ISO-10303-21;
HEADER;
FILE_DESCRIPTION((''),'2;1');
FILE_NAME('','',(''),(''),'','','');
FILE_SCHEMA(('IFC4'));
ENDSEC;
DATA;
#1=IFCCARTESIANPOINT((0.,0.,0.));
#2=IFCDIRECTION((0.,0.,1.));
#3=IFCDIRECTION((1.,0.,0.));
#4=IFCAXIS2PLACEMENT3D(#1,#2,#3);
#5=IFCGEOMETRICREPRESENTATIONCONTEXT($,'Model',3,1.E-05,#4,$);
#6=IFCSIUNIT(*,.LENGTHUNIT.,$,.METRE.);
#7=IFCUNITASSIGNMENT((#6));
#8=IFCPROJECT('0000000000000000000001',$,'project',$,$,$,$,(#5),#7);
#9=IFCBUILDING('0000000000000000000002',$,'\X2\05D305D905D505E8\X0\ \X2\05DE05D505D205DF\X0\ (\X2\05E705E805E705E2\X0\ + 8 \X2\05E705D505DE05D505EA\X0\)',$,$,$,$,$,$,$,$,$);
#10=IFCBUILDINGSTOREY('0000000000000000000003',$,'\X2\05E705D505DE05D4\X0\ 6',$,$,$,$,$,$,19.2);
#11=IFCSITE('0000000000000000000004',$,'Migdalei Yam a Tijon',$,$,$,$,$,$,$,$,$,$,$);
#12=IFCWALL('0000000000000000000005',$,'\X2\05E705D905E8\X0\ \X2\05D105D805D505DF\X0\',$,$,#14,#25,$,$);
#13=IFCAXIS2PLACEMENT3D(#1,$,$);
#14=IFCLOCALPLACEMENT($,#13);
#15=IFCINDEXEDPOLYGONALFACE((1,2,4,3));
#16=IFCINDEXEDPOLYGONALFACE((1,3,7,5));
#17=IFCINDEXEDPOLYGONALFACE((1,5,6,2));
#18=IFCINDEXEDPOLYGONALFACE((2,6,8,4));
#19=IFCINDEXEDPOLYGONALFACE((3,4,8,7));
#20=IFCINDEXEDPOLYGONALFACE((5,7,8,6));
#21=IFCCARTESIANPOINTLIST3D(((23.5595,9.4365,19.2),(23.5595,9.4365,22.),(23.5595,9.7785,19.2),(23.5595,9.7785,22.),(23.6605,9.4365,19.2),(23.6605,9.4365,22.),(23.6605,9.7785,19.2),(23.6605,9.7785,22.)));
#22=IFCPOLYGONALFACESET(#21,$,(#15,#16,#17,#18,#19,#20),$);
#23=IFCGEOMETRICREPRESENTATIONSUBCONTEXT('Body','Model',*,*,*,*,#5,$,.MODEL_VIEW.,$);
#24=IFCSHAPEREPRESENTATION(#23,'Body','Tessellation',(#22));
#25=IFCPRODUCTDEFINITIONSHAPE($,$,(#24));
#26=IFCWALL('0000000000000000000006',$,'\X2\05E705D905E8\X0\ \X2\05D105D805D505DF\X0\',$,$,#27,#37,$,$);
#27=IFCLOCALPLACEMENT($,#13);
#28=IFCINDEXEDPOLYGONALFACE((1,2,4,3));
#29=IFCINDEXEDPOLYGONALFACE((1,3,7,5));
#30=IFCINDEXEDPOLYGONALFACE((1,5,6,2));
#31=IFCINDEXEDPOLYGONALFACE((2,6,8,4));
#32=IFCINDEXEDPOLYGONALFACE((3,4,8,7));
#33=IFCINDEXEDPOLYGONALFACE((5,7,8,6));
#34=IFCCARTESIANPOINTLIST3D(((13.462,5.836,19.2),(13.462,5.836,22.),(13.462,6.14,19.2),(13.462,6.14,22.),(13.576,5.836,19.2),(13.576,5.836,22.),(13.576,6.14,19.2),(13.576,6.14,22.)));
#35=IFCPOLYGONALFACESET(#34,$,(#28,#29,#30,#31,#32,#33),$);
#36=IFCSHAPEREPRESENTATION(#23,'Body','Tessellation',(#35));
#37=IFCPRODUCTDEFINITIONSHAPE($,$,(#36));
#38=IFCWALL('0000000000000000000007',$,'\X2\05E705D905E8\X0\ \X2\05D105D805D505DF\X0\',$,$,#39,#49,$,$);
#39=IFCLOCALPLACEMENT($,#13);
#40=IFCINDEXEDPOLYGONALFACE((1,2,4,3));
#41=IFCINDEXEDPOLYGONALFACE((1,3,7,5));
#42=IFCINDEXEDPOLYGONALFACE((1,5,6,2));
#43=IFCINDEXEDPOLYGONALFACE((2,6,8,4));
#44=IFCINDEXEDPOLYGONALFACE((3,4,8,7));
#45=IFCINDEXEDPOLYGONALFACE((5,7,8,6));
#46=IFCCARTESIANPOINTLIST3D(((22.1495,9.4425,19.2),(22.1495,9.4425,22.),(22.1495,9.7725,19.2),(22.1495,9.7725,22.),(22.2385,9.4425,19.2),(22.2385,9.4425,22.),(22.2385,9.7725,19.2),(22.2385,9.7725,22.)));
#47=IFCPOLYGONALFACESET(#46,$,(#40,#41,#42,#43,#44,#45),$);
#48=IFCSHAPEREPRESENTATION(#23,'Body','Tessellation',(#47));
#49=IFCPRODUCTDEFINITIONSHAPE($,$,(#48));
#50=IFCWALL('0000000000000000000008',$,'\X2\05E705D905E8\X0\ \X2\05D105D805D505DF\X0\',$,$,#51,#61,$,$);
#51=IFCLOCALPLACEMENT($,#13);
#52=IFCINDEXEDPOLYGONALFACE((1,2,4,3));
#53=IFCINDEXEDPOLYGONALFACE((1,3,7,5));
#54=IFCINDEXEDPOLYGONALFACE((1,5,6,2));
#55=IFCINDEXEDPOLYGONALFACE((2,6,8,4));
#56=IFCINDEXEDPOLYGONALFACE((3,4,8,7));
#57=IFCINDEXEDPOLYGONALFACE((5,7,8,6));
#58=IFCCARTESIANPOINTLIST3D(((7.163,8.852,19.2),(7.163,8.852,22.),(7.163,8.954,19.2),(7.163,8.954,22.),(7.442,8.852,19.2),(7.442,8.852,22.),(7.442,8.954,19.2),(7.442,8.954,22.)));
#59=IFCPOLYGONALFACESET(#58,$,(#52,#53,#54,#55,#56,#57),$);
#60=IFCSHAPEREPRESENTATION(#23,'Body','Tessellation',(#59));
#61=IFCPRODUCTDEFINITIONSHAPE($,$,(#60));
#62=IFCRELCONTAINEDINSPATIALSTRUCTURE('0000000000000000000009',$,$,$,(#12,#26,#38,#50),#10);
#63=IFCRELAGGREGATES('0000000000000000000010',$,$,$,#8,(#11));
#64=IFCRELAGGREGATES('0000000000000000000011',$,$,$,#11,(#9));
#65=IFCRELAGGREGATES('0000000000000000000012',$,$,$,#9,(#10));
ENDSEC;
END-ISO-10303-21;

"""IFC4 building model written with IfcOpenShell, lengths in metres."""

from ifc_helpers import new_model, si_unit, frame, origin_with_axes, context, subcontext, project, spatial, line, indexed_curve, outline, extrude, element, save


model = new_model("IFC4")

# Units and contexts
model_context = context("Model", 3, precision=1e-05, world=origin_with_axes())
body_context = subcontext(model_context, "Body", "Model", "MODEL_VIEW")
ifc_project = project(units=[si_unit("LENGTHUNIT", "METRE")], contexts=[model_context])

# Site, building, storey
site = spatial("IfcSite", under=ifc_project, Name="Migdalei Yam a Tijon")
building = spatial("IfcBuilding", under=site, Name="דיור מוגן (קרקע + 8 קומות)")
storey = spatial("IfcBuildingStorey", under=building, Name="קומה 6", Elevation=19.2)

# Walls
element("IfcWall", 1, inside=storey, Name="קיר בטון", context=body_context, shape_type="SweptSolid", body=[
    extrude(outline(indexed_curve([(0.0, 0.0), (0.101, 0.0), (0.101, 0.342), (0.0, 0.342)], segments=[line(1, 2, 3, 4, 1)])), frame((23.5595, 9.4365, 19.2), z_axis=(0.0, 0.0, 1.0), x_axis=(1.0, 0.0, 0.0)), (0.0, 0.0, 1.0), 2.8),
])
element("IfcWall", 2, inside=storey, Name="קיר בטון", context=body_context, shape_type="SweptSolid", body=[
    extrude(outline(indexed_curve([(0.0, 0.0), (0.114, 0.0), (0.114, 0.304), (0.0, 0.304)], segments=[line(1, 2, 3, 4, 1)])), frame((13.462, 5.836, 19.2), z_axis=(0.0, 0.0, 1.0), x_axis=(1.0, 0.0, 0.0)), (0.0, 0.0, 1.0), 2.8),
])
element("IfcWall", 3, inside=storey, Name="קיר בטון", context=body_context, shape_type="SweptSolid", body=[
    extrude(outline(indexed_curve([(0.0, 0.0), (0.089, 0.0), (0.089, 0.33), (0.0, 0.33)], segments=[line(1, 2, 3, 4, 1)])), frame((22.1495, 9.4425, 19.2), z_axis=(0.0, 0.0, 1.0), x_axis=(1.0, 0.0, 0.0)), (0.0, 0.0, 1.0), 2.8),
])
element("IfcWall", 4, inside=storey, Name="קיר בטון", context=body_context, shape_type="SweptSolid", body=[
    extrude(outline(indexed_curve([(0.0, 0.0), (0.279, 0.0), (0.279, 0.102), (0.0, 0.102)], segments=[line(1, 2, 3, 4, 1)])), frame((7.163, 8.852, 19.2), z_axis=(0.0, 0.0, 1.0), x_axis=(1.0, 0.0, 0.0)), (0.0, 0.0, 1.0), 2.8),
])

save(model, "model.ifc")
